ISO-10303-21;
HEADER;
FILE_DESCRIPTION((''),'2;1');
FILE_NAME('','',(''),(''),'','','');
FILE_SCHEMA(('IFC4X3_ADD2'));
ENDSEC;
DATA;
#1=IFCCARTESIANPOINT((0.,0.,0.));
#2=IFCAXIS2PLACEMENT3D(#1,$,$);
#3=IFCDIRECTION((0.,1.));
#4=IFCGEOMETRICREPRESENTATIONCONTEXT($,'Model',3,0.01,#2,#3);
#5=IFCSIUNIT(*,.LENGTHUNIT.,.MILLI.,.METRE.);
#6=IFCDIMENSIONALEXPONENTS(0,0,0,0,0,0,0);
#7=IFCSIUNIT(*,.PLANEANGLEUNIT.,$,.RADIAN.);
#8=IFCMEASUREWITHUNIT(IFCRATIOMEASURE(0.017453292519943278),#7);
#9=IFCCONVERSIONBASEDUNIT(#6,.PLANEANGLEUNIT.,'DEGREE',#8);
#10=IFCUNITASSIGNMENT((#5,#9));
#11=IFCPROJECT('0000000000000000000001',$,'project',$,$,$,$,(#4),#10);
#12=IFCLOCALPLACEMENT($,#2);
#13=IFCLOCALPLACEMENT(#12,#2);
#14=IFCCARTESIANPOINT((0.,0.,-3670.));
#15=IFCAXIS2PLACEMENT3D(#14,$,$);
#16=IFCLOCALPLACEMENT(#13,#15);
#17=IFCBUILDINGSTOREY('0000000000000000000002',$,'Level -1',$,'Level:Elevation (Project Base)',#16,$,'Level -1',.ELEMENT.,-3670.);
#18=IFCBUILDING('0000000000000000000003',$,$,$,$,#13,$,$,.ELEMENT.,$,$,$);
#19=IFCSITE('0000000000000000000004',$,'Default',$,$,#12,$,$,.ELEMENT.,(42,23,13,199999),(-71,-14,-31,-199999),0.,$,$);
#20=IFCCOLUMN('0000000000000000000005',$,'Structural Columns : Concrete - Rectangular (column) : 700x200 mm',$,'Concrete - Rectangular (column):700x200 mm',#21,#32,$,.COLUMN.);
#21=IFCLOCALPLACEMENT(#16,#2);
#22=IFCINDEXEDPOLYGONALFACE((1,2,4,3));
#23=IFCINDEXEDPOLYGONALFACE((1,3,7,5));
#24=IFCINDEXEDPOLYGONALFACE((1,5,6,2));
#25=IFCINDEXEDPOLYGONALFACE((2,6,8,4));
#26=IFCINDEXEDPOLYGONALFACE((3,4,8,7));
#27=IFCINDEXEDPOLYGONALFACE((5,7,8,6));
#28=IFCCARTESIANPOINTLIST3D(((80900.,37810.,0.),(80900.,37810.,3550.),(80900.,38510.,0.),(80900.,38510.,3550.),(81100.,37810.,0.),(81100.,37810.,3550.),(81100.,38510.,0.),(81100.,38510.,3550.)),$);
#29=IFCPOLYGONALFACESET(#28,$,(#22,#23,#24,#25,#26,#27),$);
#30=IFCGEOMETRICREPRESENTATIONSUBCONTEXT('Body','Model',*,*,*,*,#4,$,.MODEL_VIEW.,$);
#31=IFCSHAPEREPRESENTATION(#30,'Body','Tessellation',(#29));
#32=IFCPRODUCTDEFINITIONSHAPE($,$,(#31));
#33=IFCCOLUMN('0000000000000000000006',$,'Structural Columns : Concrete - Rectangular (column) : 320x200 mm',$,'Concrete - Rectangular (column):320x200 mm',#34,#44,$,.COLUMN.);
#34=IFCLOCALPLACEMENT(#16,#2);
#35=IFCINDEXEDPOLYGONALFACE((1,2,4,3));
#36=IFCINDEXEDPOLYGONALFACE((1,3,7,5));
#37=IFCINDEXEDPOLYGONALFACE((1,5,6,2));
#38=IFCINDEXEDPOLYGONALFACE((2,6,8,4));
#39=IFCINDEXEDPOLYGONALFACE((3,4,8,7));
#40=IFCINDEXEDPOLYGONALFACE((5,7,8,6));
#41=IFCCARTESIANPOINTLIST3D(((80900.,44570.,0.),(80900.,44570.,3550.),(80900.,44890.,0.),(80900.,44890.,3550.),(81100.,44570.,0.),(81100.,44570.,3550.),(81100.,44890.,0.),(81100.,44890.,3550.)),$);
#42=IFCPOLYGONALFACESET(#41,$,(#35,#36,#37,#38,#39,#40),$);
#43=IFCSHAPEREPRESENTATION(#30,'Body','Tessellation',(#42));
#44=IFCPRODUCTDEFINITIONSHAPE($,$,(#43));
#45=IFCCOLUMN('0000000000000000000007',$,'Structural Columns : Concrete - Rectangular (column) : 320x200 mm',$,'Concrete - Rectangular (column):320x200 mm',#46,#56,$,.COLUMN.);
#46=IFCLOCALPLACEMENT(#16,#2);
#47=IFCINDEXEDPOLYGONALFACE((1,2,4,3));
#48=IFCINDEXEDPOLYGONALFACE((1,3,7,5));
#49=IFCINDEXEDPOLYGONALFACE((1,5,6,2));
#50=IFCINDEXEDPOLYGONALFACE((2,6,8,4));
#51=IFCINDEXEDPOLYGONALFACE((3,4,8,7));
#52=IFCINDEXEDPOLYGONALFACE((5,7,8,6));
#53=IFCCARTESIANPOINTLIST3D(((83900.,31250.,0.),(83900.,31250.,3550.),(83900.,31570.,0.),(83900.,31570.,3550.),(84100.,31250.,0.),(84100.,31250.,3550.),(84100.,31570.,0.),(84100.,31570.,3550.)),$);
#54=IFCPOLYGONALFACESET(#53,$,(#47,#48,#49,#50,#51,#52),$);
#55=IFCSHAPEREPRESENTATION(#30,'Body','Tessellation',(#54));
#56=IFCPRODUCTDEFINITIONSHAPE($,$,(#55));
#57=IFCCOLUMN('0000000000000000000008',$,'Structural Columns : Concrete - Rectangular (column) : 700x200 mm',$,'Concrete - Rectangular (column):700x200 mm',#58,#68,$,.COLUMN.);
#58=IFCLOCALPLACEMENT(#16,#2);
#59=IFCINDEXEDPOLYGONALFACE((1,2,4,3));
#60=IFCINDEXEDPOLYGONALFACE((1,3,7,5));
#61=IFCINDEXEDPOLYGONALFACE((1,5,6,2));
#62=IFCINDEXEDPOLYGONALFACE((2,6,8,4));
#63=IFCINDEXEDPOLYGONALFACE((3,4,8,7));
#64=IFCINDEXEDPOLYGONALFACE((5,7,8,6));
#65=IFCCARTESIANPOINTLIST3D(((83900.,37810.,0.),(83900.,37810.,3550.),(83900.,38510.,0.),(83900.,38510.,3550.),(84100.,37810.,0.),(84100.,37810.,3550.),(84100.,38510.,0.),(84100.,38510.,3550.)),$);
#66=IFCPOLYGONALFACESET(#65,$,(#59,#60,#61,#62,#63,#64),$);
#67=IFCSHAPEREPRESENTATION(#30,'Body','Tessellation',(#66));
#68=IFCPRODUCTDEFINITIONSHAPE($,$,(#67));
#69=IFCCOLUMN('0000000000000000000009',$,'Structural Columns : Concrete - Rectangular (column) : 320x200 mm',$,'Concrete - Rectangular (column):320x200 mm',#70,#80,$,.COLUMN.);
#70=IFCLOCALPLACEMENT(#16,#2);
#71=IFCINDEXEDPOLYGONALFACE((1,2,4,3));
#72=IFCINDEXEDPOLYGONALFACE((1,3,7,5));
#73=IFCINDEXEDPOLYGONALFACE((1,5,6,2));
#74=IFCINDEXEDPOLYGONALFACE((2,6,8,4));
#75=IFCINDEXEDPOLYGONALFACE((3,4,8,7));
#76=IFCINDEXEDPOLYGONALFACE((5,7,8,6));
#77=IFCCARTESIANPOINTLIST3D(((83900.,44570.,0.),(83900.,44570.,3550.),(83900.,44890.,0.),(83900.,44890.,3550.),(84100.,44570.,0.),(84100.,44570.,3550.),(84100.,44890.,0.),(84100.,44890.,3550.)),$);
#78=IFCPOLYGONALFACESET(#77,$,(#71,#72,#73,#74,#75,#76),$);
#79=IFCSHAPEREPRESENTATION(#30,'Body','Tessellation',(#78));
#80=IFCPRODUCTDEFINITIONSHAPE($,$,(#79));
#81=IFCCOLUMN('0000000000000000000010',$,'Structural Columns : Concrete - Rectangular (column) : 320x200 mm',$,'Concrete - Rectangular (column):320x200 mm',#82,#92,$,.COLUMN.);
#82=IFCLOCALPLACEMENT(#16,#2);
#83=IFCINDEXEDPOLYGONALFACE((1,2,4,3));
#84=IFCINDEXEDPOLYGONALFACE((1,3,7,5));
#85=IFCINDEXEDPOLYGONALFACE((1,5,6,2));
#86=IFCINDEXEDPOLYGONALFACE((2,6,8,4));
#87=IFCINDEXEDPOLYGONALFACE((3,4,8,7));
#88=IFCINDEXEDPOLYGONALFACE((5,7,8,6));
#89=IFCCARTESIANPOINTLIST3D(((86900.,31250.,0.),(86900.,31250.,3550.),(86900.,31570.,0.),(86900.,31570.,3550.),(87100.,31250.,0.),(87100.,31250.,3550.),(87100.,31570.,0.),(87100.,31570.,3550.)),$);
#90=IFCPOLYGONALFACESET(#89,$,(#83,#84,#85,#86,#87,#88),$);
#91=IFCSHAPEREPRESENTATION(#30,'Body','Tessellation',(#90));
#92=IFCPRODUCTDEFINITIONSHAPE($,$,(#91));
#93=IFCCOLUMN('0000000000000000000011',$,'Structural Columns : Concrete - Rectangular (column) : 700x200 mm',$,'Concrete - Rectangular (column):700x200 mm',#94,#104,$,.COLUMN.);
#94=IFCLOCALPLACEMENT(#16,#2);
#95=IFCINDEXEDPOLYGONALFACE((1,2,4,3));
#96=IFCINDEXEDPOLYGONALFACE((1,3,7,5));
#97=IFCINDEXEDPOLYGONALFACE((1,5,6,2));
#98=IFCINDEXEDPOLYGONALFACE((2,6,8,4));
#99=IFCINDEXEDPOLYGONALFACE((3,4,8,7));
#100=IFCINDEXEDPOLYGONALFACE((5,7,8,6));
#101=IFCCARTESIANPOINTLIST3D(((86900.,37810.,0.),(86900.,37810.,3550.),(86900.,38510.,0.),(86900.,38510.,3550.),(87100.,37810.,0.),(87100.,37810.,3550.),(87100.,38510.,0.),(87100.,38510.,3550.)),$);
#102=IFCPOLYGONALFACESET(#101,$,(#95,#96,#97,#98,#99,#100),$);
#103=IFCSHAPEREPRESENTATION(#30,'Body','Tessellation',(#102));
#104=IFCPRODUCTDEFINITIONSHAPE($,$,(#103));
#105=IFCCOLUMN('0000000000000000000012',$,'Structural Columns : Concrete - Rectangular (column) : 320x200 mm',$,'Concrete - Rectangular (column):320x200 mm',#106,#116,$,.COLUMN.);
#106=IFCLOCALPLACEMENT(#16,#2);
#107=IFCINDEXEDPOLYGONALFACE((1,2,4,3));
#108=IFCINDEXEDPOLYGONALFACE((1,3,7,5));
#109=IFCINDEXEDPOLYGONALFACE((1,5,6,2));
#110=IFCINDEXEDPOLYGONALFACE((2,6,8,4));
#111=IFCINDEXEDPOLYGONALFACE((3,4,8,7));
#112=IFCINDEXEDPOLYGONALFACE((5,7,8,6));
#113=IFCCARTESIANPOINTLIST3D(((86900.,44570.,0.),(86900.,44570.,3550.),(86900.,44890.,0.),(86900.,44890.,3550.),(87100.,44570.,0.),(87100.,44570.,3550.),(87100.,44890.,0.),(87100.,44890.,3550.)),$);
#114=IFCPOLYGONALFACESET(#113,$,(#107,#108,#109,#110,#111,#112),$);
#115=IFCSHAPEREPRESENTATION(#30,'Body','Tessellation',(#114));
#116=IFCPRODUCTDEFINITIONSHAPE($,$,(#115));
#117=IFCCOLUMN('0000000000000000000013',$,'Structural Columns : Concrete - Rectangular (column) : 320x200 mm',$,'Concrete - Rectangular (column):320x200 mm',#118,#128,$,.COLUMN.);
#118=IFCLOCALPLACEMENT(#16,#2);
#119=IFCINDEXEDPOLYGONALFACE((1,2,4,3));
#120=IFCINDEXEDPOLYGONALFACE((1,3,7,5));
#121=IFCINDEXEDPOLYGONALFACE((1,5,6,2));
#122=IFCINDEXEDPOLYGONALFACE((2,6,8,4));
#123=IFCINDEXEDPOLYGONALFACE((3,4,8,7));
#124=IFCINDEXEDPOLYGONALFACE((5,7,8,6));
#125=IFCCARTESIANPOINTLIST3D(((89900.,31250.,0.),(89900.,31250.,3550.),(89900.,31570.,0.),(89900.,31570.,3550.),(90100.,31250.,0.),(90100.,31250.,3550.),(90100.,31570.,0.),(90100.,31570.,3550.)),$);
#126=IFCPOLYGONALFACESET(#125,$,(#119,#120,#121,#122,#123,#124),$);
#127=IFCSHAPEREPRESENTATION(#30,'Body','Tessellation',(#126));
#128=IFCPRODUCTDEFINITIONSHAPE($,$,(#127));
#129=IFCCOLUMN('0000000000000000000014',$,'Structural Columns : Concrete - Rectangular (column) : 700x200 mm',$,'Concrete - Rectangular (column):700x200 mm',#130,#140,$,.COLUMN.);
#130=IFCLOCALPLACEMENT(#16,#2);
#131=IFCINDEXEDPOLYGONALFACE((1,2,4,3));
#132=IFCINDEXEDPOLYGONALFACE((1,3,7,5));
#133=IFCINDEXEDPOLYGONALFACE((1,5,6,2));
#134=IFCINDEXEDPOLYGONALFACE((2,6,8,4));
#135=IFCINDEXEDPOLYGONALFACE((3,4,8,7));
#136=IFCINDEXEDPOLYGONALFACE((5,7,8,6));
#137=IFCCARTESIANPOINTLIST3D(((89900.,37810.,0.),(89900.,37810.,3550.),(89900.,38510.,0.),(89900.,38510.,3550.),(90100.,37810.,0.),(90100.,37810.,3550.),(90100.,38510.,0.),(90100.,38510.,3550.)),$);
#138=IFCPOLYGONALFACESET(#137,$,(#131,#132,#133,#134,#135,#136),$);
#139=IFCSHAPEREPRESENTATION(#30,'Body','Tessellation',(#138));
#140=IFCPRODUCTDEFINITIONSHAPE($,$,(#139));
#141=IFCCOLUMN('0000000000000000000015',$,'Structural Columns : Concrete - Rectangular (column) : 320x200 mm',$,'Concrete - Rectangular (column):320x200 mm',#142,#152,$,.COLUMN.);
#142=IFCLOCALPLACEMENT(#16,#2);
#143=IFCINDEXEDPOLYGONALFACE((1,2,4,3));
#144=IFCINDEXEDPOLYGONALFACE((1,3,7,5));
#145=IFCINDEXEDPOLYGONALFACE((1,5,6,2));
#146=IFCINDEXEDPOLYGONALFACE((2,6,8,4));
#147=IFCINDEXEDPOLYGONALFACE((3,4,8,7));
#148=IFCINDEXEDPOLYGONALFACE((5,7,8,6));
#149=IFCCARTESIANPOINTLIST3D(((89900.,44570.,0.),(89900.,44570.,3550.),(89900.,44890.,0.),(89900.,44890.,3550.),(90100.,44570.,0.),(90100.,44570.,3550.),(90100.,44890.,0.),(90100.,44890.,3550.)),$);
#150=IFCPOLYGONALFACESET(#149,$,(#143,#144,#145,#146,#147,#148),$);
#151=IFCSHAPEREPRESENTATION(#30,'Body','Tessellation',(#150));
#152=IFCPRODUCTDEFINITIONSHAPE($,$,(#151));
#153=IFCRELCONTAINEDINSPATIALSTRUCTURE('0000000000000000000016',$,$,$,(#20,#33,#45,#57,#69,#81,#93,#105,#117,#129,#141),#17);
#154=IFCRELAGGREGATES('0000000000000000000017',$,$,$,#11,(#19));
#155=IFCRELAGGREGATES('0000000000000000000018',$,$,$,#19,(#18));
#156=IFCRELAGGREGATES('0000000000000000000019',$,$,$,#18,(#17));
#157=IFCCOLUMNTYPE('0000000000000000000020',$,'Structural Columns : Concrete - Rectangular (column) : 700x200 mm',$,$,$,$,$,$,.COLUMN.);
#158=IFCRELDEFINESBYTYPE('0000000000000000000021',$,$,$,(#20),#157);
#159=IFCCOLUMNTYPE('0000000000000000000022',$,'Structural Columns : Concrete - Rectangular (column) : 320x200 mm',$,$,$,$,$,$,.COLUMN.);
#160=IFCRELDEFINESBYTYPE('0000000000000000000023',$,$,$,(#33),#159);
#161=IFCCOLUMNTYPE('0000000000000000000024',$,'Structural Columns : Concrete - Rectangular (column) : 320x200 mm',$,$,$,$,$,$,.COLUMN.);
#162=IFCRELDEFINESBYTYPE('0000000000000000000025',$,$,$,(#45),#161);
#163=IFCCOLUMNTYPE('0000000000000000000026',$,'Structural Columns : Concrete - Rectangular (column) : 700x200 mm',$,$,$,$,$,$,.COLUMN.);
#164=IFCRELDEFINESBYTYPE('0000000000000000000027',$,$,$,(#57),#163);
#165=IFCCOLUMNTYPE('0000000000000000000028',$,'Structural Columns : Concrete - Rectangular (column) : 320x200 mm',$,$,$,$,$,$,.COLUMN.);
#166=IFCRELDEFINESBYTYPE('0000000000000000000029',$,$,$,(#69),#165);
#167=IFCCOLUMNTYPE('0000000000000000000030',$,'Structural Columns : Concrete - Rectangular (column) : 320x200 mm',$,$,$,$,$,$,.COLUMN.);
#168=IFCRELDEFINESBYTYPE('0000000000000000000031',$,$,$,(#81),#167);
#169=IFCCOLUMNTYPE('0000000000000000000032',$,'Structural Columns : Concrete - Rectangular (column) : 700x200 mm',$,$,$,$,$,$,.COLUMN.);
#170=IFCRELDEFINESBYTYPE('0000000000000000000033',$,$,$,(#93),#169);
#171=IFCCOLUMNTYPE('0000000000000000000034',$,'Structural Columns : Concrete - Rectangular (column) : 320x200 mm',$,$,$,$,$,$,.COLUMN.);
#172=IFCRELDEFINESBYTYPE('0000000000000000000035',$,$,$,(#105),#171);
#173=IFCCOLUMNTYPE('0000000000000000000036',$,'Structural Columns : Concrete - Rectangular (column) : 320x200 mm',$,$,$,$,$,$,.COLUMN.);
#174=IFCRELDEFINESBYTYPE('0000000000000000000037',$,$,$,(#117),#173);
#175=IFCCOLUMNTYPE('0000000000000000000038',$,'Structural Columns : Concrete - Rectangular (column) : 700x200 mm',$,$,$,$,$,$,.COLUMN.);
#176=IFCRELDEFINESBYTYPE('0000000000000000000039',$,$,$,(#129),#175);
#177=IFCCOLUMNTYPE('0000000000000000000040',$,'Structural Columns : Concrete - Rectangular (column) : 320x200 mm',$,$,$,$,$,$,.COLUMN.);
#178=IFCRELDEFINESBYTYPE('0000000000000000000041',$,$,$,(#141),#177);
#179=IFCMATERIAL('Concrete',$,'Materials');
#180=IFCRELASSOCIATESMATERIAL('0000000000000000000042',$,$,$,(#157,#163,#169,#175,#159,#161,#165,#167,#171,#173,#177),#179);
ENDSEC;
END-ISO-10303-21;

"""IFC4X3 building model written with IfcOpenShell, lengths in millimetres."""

from ifc_helpers import new_model, entity, si_unit, converted_unit, direction, frame, frame_2d, origin, origin_2d_with_axis, place, context, subcontext, project, spatial, rectangle, extrude, source, transform, mapped, material, material_profile, profile_set, type_object, type_shapes, element, save


model = new_model("IFC4X3")

# Units and contexts
model_context = context("Model", 3, precision=0.01, world=origin(), true_north=direction((0.0, 1.0)))
body_context = subcontext(model_context, "Body", "Model", "MODEL_VIEW")
ifc_project = project(units=[si_unit("LENGTHUNIT", "METRE", prefix="MILLI"), converted_unit("PLANEANGLEUNIT", "DEGREE", entity("IfcRatioMeasure", 0.017453292519943278), si_unit("PLANEANGLEUNIT", "RADIAN"), dimensions=[0, 0, 0, 0, 0, 0, 0])], contexts=[model_context])

# Site, building, storey
site_placement = place(None, origin())
site = spatial("IfcSite", under=ifc_project, at=site_placement, Name="Default", CompositionType="ELEMENT", RefLatitude=(42, 23, 13, 199999), RefLongitude=(-71, -14, -31, -199999), RefElevation=0.0)
building_placement = place(site_placement, origin())
building = spatial("IfcBuilding", under=site, at=building_placement, CompositionType="ELEMENT")
storey_placement = place(building_placement, frame((0.0, 0.0, -3670.0)))
storey = spatial("IfcBuildingStorey", under=building, at=storey_placement, Name="Level -1", ObjectType="Level:Elevation (Project Base)", LongName="Level -1", CompositionType="ELEMENT", Elevation=-3670.0)

# Columns
ifc_material = material(Name="Concrete", Category="Materials")
ifc_material_profile_1 = material_profile(ifc_material, rectangle(XDim=320.0, YDim=200.0, at=frame_2d((0.0, 0.0), x_axis=(1.0, 0.0))), Name="320x200 mm")
ifc_profile_set_1 = profile_set([ifc_material_profile_1], Name="320x200 mm")
ifc_material_profile_2 = material_profile(ifc_material, rectangle(XDim=700.0, YDim=200.0, at=frame_2d((0.0, 0.0), x_axis=(1.0, 0.0))), Name="700x200 mm")
ifc_profile_set_2 = profile_set([ifc_material_profile_2], Name="700x200 mm")
column_type_1 = type_object("IfcColumnType", Name="Structural Columns : Concrete - Rectangular (column) : 700x200 mm", PredefinedType="COLUMN", material=ifc_profile_set_2)
shared_shape_1 = source(origin(), body_context, "Body", "SweptSolid", [
    extrude(rectangle(XDim=700.0, YDim=200.0, at=origin_2d_with_axis()), frame((81000.0, 38160.0, -3670.0), z_axis=(0.0, 0.0, 1.0), x_axis=(0.0, -1.0, 0.0)), (0.0, 0.0, 1.0), 3550.0),
])
type_shapes(column_type_1, [shared_shape_1])
column_1_placement = place(storey_placement, frame((0.0, 0.0, 3670.0)))
element("IfcColumn", 1, at=column_1_placement, inside=storey, type_object=column_type_1, Name="Structural Columns : Concrete - Rectangular (column) : 700x200 mm", ObjectType="Concrete - Rectangular (column):700x200 mm", PredefinedType="COLUMN", context=body_context, shape_type="MappedRepresentation", body=[
    mapped(shared_shape_1, transform((0.0, 0.0, 0.0), scale=1.0)),
])
column_type_2 = type_object("IfcColumnType", Name="Structural Columns : Concrete - Rectangular (column) : 320x200 mm", PredefinedType="COLUMN", material=ifc_profile_set_1)
shared_shape_2 = source(origin(), body_context, "Body", "SweptSolid", [
    extrude(rectangle(XDim=320.0, YDim=200.0, at=origin_2d_with_axis()), frame((81000.0, 44730.0, -3670.0), z_axis=(0.0, 0.0, 1.0), x_axis=(0.0, -1.0, 0.0)), (0.0, 0.0, 1.0), 3550.0),
])
type_shapes(column_type_2, [shared_shape_2])
column_2_placement = place(storey_placement, frame((0.0, 0.0, 3670.0)))
element("IfcColumn", 2, at=column_2_placement, inside=storey, type_object=column_type_2, Name="Structural Columns : Concrete - Rectangular (column) : 320x200 mm", ObjectType="Concrete - Rectangular (column):320x200 mm", PredefinedType="COLUMN", context=body_context, shape_type="MappedRepresentation", body=[
    mapped(shared_shape_2, transform((0.0, 0.0, 0.0), scale=1.0)),
])
column_type_3 = type_object("IfcColumnType", Name="Structural Columns : Concrete - Rectangular (column) : 320x200 mm", PredefinedType="COLUMN", material=ifc_profile_set_1)
shared_shape_3 = source(origin(), body_context, "Body", "SweptSolid", [
    extrude(rectangle(XDim=320.0, YDim=200.0, at=origin_2d_with_axis()), frame((84000.0, 31410.0, -3670.0), z_axis=(0.0, 0.0, 1.0), x_axis=(0.0, -1.0, 0.0)), (0.0, 0.0, 1.0), 3550.0),
])
type_shapes(column_type_3, [shared_shape_3])
column_3_placement = place(storey_placement, frame((0.0, 0.0, 3670.0)))
element("IfcColumn", 3, at=column_3_placement, inside=storey, type_object=column_type_3, Name="Structural Columns : Concrete - Rectangular (column) : 320x200 mm", ObjectType="Concrete - Rectangular (column):320x200 mm", PredefinedType="COLUMN", context=body_context, shape_type="MappedRepresentation", body=[
    mapped(shared_shape_3, transform((0.0, 0.0, 0.0), scale=1.0)),
])
column_type_4 = type_object("IfcColumnType", Name="Structural Columns : Concrete - Rectangular (column) : 700x200 mm", PredefinedType="COLUMN", material=ifc_profile_set_2)
shared_shape_4 = source(origin(), body_context, "Body", "SweptSolid", [
    extrude(rectangle(XDim=700.0, YDim=200.0, at=origin_2d_with_axis()), frame((84000.0, 38160.0, -3670.0), z_axis=(0.0, 0.0, 1.0), x_axis=(0.0, -1.0, 0.0)), (0.0, 0.0, 1.0), 3550.0),
])
type_shapes(column_type_4, [shared_shape_4])
column_4_placement = place(storey_placement, frame((0.0, 0.0, 3670.0)))
element("IfcColumn", 4, at=column_4_placement, inside=storey, type_object=column_type_4, Name="Structural Columns : Concrete - Rectangular (column) : 700x200 mm", ObjectType="Concrete - Rectangular (column):700x200 mm", PredefinedType="COLUMN", context=body_context, shape_type="MappedRepresentation", body=[
    mapped(shared_shape_4, transform((0.0, 0.0, 0.0), scale=1.0)),
])
column_type_5 = type_object("IfcColumnType", Name="Structural Columns : Concrete - Rectangular (column) : 320x200 mm", PredefinedType="COLUMN", material=ifc_profile_set_1)
shared_shape_5 = source(origin(), body_context, "Body", "SweptSolid", [
    extrude(rectangle(XDim=320.0, YDim=200.0, at=origin_2d_with_axis()), frame((84000.0, 44730.0, -3670.0), z_axis=(0.0, 0.0, 1.0), x_axis=(0.0, -1.0, 0.0)), (0.0, 0.0, 1.0), 3550.0),
])
type_shapes(column_type_5, [shared_shape_5])
column_5_placement = place(storey_placement, frame((0.0, 0.0, 3670.0)))
element("IfcColumn", 5, at=column_5_placement, inside=storey, type_object=column_type_5, Name="Structural Columns : Concrete - Rectangular (column) : 320x200 mm", ObjectType="Concrete - Rectangular (column):320x200 mm", PredefinedType="COLUMN", context=body_context, shape_type="MappedRepresentation", body=[
    mapped(shared_shape_5, transform((0.0, 0.0, 0.0), scale=1.0)),
])
column_type_6 = type_object("IfcColumnType", Name="Structural Columns : Concrete - Rectangular (column) : 320x200 mm", PredefinedType="COLUMN", material=ifc_profile_set_1)
shared_shape_6 = source(origin(), body_context, "Body", "SweptSolid", [
    extrude(rectangle(XDim=320.0, YDim=200.0, at=origin_2d_with_axis()), frame((87000.0, 31410.0, -3670.0), z_axis=(0.0, 0.0, 1.0), x_axis=(0.0, -1.0, 0.0)), (0.0, 0.0, 1.0), 3550.0),
])
type_shapes(column_type_6, [shared_shape_6])
column_6_placement = place(storey_placement, frame((0.0, 0.0, 3670.0)))
element("IfcColumn", 6, at=column_6_placement, inside=storey, type_object=column_type_6, Name="Structural Columns : Concrete - Rectangular (column) : 320x200 mm", ObjectType="Concrete - Rectangular (column):320x200 mm", PredefinedType="COLUMN", context=body_context, shape_type="MappedRepresentation", body=[
    mapped(shared_shape_6, transform((0.0, 0.0, 0.0), scale=1.0)),
])
column_type_7 = type_object("IfcColumnType", Name="Structural Columns : Concrete - Rectangular (column) : 700x200 mm", PredefinedType="COLUMN", material=ifc_profile_set_2)
shared_shape_7 = source(origin(), body_context, "Body", "SweptSolid", [
    extrude(rectangle(XDim=700.0, YDim=200.0, at=origin_2d_with_axis()), frame((87000.0, 38160.0, -3670.0), z_axis=(0.0, 0.0, 1.0), x_axis=(0.0, -1.0, 0.0)), (0.0, 0.0, 1.0), 3550.0),
])
type_shapes(column_type_7, [shared_shape_7])
column_7_placement = place(storey_placement, frame((0.0, 0.0, 3670.0)))
element("IfcColumn", 7, at=column_7_placement, inside=storey, type_object=column_type_7, Name="Structural Columns : Concrete - Rectangular (column) : 700x200 mm", ObjectType="Concrete - Rectangular (column):700x200 mm", PredefinedType="COLUMN", context=body_context, shape_type="MappedRepresentation", body=[
    mapped(shared_shape_7, transform((0.0, 0.0, 0.0), scale=1.0)),
])
column_type_8 = type_object("IfcColumnType", Name="Structural Columns : Concrete - Rectangular (column) : 320x200 mm", PredefinedType="COLUMN", material=ifc_profile_set_1)
shared_shape_8 = source(origin(), body_context, "Body", "SweptSolid", [
    extrude(rectangle(XDim=320.0, YDim=200.0, at=origin_2d_with_axis()), frame((87000.0, 44730.0, -3670.0), z_axis=(0.0, 0.0, 1.0), x_axis=(0.0, -1.0, 0.0)), (0.0, 0.0, 1.0), 3550.0),
])
type_shapes(column_type_8, [shared_shape_8])
column_8_placement = place(storey_placement, frame((0.0, 0.0, 3670.0)))
element("IfcColumn", 8, at=column_8_placement, inside=storey, type_object=column_type_8, Name="Structural Columns : Concrete - Rectangular (column) : 320x200 mm", ObjectType="Concrete - Rectangular (column):320x200 mm", PredefinedType="COLUMN", context=body_context, shape_type="MappedRepresentation", body=[
    mapped(shared_shape_8, transform((0.0, 0.0, 0.0), scale=1.0)),
])
column_type_9 = type_object("IfcColumnType", Name="Structural Columns : Concrete - Rectangular (column) : 320x200 mm", PredefinedType="COLUMN", material=ifc_profile_set_1)
shared_shape_9 = source(origin(), body_context, "Body", "SweptSolid", [
    extrude(rectangle(XDim=320.0, YDim=200.0, at=origin_2d_with_axis()), frame((90000.0, 31410.0, -3670.0), z_axis=(0.0, 0.0, 1.0), x_axis=(0.0, -1.0, 0.0)), (0.0, 0.0, 1.0), 3550.0),
])
type_shapes(column_type_9, [shared_shape_9])
column_9_placement = place(storey_placement, frame((0.0, 0.0, 3670.0)))
element("IfcColumn", 9, at=column_9_placement, inside=storey, type_object=column_type_9, Name="Structural Columns : Concrete - Rectangular (column) : 320x200 mm", ObjectType="Concrete - Rectangular (column):320x200 mm", PredefinedType="COLUMN", context=body_context, shape_type="MappedRepresentation", body=[
    mapped(shared_shape_9, transform((0.0, 0.0, 0.0), scale=1.0)),
])
column_type_10 = type_object("IfcColumnType", Name="Structural Columns : Concrete - Rectangular (column) : 700x200 mm", PredefinedType="COLUMN", material=ifc_profile_set_2)
shared_shape_10 = source(origin(), body_context, "Body", "SweptSolid", [
    extrude(rectangle(XDim=700.0, YDim=200.0, at=origin_2d_with_axis()), frame((90000.0, 38160.0, -3670.0), z_axis=(0.0, 0.0, 1.0), x_axis=(0.0, -1.0, 0.0)), (0.0, 0.0, 1.0), 3550.0),
])
type_shapes(column_type_10, [shared_shape_10])
column_10_placement = place(storey_placement, frame((0.0, 0.0, 3670.0)))
element("IfcColumn", 10, at=column_10_placement, inside=storey, type_object=column_type_10, Name="Structural Columns : Concrete - Rectangular (column) : 700x200 mm", ObjectType="Concrete - Rectangular (column):700x200 mm", PredefinedType="COLUMN", context=body_context, shape_type="MappedRepresentation", body=[
    mapped(shared_shape_10, transform((0.0, 0.0, 0.0), scale=1.0)),
])
column_type_11 = type_object("IfcColumnType", Name="Structural Columns : Concrete - Rectangular (column) : 320x200 mm", PredefinedType="COLUMN", material=ifc_profile_set_1)
shared_shape_11 = source(origin(), body_context, "Body", "SweptSolid", [
    extrude(rectangle(XDim=320.0, YDim=200.0, at=origin_2d_with_axis()), frame((90000.0, 44730.0, -3670.0), z_axis=(0.0, 0.0, 1.0), x_axis=(0.0, -1.0, 0.0)), (0.0, 0.0, 1.0), 3550.0),
])
type_shapes(column_type_11, [shared_shape_11])
column_11_placement = place(storey_placement, frame((0.0, 0.0, 3670.0)))
element("IfcColumn", 11, at=column_11_placement, inside=storey, type_object=column_type_11, Name="Structural Columns : Concrete - Rectangular (column) : 320x200 mm", ObjectType="Concrete - Rectangular (column):320x200 mm", PredefinedType="COLUMN", context=body_context, shape_type="MappedRepresentation", body=[
    mapped(shared_shape_11, transform((0.0, 0.0, 0.0), scale=1.0)),
])

save(model, "model.ifc")
